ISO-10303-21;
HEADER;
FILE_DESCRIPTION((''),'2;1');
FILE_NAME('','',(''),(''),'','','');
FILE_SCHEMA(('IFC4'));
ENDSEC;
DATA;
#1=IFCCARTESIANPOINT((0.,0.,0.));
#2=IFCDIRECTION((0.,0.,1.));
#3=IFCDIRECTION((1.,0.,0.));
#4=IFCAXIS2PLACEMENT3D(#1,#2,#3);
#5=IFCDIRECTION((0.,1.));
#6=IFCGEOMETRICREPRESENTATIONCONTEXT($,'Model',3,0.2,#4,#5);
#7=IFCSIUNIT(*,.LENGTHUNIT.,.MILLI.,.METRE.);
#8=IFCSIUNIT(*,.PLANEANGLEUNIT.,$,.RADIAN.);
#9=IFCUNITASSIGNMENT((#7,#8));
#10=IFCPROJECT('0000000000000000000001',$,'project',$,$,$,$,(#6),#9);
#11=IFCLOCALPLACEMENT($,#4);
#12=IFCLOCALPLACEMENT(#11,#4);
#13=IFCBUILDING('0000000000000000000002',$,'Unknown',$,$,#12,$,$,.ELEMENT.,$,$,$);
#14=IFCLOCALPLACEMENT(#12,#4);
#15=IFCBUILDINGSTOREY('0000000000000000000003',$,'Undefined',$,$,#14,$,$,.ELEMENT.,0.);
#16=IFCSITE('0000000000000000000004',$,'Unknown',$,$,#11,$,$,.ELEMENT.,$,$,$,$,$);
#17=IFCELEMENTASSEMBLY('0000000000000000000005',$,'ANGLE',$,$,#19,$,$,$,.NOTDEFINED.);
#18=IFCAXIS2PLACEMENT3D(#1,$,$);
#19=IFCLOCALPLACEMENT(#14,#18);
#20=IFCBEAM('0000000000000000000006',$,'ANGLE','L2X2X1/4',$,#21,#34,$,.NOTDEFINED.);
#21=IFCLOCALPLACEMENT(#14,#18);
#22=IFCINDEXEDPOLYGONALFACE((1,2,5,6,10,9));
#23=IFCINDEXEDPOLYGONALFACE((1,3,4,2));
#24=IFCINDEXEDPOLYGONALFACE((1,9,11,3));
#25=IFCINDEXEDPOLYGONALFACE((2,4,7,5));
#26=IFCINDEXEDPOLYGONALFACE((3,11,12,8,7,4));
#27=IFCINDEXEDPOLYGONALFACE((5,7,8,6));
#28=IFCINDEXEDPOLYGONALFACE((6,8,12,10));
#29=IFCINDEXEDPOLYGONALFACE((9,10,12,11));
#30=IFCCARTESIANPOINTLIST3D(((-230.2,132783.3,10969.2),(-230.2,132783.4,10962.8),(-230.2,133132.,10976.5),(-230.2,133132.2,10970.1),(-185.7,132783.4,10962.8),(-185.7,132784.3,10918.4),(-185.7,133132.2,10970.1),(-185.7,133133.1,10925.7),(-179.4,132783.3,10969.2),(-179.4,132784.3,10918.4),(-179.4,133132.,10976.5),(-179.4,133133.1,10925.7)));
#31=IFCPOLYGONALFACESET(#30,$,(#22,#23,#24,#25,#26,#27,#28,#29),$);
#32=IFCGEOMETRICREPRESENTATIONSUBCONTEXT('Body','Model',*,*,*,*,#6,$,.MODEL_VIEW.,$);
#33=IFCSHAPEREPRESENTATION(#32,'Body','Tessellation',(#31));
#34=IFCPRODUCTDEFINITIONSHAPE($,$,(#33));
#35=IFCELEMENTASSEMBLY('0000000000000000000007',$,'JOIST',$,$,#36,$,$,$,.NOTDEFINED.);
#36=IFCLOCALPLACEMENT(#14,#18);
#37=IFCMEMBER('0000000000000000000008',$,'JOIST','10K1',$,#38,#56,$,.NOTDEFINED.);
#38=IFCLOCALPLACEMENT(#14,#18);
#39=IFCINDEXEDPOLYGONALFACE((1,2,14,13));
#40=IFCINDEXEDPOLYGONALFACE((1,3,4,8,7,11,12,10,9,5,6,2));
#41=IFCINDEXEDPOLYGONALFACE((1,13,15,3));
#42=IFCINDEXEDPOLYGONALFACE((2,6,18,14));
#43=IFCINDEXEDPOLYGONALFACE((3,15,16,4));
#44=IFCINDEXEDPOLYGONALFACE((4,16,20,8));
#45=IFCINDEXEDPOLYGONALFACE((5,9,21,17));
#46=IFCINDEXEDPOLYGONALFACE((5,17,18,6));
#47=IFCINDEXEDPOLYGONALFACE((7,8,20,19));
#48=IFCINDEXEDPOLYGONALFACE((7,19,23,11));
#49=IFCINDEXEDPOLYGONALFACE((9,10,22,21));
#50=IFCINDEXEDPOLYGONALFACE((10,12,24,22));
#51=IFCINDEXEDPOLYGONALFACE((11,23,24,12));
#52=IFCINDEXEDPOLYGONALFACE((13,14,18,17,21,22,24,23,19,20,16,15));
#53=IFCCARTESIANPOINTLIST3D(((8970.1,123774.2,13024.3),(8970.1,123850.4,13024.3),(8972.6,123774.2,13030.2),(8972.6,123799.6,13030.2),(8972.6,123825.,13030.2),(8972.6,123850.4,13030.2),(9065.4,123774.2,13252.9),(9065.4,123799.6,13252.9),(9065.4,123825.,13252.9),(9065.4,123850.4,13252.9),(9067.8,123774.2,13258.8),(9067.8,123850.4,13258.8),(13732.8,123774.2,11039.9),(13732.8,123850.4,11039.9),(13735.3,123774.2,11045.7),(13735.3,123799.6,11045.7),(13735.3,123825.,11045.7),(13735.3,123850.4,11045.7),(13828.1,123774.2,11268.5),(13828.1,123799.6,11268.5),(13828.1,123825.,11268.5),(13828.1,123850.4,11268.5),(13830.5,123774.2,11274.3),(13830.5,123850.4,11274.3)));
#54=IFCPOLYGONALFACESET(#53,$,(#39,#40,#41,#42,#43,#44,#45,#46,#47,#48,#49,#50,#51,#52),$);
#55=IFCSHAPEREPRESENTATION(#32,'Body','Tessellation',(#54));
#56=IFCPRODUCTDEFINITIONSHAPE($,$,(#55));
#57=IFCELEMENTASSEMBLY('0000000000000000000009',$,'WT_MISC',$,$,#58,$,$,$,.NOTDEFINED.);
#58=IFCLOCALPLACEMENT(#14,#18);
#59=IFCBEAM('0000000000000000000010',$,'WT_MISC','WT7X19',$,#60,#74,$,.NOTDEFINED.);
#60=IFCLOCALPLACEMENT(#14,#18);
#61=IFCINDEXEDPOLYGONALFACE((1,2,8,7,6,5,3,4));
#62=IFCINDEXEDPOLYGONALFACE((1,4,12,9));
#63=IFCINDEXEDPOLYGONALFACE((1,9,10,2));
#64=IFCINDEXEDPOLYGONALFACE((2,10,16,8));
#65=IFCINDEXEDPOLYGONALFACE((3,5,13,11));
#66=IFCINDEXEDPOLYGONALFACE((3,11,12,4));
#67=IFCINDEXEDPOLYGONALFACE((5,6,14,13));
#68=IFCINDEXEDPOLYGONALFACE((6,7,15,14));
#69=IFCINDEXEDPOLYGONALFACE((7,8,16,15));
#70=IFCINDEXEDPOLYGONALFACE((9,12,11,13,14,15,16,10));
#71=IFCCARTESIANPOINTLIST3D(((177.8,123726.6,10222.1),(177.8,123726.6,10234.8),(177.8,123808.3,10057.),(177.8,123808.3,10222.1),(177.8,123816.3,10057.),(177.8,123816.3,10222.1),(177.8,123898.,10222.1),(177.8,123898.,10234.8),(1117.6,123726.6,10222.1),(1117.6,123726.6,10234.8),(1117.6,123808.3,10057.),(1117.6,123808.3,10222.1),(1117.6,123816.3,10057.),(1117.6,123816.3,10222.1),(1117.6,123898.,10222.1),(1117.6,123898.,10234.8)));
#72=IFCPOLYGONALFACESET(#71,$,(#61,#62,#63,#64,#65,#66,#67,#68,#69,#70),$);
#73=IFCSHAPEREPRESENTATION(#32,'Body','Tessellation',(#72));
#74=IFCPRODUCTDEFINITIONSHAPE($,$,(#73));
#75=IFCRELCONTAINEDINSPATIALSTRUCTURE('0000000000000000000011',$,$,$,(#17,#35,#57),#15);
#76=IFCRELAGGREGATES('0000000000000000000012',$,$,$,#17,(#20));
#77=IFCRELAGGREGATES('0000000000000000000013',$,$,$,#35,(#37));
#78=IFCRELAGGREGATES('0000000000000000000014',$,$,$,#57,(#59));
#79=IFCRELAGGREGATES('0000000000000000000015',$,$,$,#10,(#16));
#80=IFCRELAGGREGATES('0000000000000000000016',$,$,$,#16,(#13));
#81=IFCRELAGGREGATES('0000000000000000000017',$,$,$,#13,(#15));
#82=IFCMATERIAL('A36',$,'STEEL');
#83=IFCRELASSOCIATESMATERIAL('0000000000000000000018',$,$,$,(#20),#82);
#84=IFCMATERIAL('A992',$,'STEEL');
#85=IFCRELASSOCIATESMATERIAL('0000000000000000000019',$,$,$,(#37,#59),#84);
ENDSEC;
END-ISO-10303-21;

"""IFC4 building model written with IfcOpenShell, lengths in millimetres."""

from ifc_helpers import new_model, si_unit, direction, frame, origin_with_axes, place, context, subcontext, project, spatial, line, indexed_curve, outline, extrude, material, element, aggregate, save


model = new_model("IFC4")

# Units and contexts
model_context = context("Model", 3, precision=0.2, world=origin_with_axes(), true_north=direction((0.0, 1.0)))
body_context = subcontext(model_context, "Body", "Model", "MODEL_VIEW")
ifc_project = project(units=[si_unit("LENGTHUNIT", "METRE", prefix="MILLI"), si_unit("PLANEANGLEUNIT", "RADIAN")], contexts=[model_context])

# Site, building, storey
site_placement = place(None, origin_with_axes())
site = spatial("IfcSite", under=ifc_project, at=site_placement, Name="Unknown", CompositionType="ELEMENT")
building_placement = place(site_placement, origin_with_axes())
building = spatial("IfcBuilding", under=site, at=building_placement, Name="Unknown", CompositionType="ELEMENT")
storey_placement = place(building_placement, origin_with_axes())
storey = spatial("IfcBuildingStorey", under=building, at=storey_placement, Name="Undefined", CompositionType="ELEMENT", Elevation=0.0)

# Shared definitions
ifc_material_1 = material(Name="A992", Category="STEEL")
ifc_material_2 = material(Name="A36", Category="STEEL")

# Element assembly, beam
assembly_1_placement = place(storey_placement, frame((-204.8, 133132.6, 10951.1), z_axis=(0.0, 0.020829, -0.999783), x_axis=(0.0, -0.999783, -0.020831)))
assembly_1 = element("IfcElementAssembly", 1, at=assembly_1_placement, inside=storey, Name="ANGLE", PredefinedType="NOTDEFINED")
beam_1_placement = place(assembly_1_placement, origin_with_axes())
beam_1 = element("IfcBeam", 2, at=beam_1_placement, material=ifc_material_2, Name="ANGLE", Description="L2X2X1/4", PredefinedType="NOTDEFINED", context=body_context, shape_type="SolidModel", body=[
    extrude(outline(indexed_curve([(-25.4, -25.4), (25.4, -25.4), (25.4, -19.1), (-19.1, -19.1), (-19.1, 25.4), (-25.4, 25.4)], segments=[line(1, 2, 3, 4, 5, 6, 1)])), frame((0.0, 0.0, 0.0), z_axis=(-1.0, 0.0, 0.0), x_axis=(0.0, 0.0, 1.0)), (0.0, 0.0, -1.0), 348.9),
])
aggregate(assembly_1, [beam_1])

# Element assembly, member
assembly_2_placement = place(storey_placement, frame((9019.0, 123812.3, 13141.6), z_axis=(0.0, -1.0, 0.0), x_axis=(0.923077, 0.000001, -0.384615)))
assembly_2 = element("IfcElementAssembly", 3, at=assembly_2_placement, inside=storey, Name="JOIST", PredefinedType="NOTDEFINED")
member_1_placement = place(assembly_2_placement, origin_with_axes())
member_1 = element("IfcMember", 4, at=member_1_placement, material=ifc_material_1, Name="JOIST", Description="10K1", PredefinedType="NOTDEFINED", context=body_context, shape_type="SolidModel", body=[
    extrude(outline(indexed_curve([(-38.1, -127.0), (38.1, -127.0), (38.1, -120.7), (12.7, -120.7), (12.7, 120.7), (38.1, 120.7), (38.1, 127.0), (-38.1, 127.0), (-38.1, 120.7), (-12.7, 120.7), (-12.7, -120.7), (-38.1, -120.7)], segments=[line(1, 2, 3, 4, 5, 6, 7, 8, 9, 10, 11, 12, 1)])), frame((0.0, 0.0, 0.0), z_axis=(-1.0, 0.0, 0.0), x_axis=(0.0, 0.0, 1.0)), (0.0, 0.0, -1.0), 5159.6),
])
aggregate(assembly_2, [member_1])

# Element assembly, beam
assembly_3_placement = place(storey_placement, frame((177.8, 123812.3, 10145.9), z_axis=(0.0, -1.0, 0.0), x_axis=(1.0, 0.0, 0.0)))
assembly_3 = element("IfcElementAssembly", 5, at=assembly_3_placement, inside=storey, Name="WT_MISC", PredefinedType="NOTDEFINED")
beam_2_placement = place(assembly_3_placement, origin_with_axes())
beam_2 = element("IfcBeam", 6, at=beam_2_placement, material=ifc_material_1, Name="WT_MISC", Description="WT7X19", PredefinedType="NOTDEFINED", context=body_context, shape_type="SolidModel", body=[
    extrude(outline(indexed_curve([(-4.0, -88.9), (4.0, -88.9), (4.0, 76.2), (85.7, 76.2), (85.7, 88.9), (-85.7, 88.9), (-85.7, 76.2), (-4.0, 76.2)], segments=[line(1, 2, 3, 4, 5, 6, 7, 8, 1)])), frame((0.0, 0.0, 0.0), z_axis=(-1.0, 0.0, 0.0), x_axis=(0.0, 0.0, 1.0)), (0.0, 0.0, -1.0), 939.8),
])
aggregate(assembly_3, [beam_2])

save(model, "model.ifc")
